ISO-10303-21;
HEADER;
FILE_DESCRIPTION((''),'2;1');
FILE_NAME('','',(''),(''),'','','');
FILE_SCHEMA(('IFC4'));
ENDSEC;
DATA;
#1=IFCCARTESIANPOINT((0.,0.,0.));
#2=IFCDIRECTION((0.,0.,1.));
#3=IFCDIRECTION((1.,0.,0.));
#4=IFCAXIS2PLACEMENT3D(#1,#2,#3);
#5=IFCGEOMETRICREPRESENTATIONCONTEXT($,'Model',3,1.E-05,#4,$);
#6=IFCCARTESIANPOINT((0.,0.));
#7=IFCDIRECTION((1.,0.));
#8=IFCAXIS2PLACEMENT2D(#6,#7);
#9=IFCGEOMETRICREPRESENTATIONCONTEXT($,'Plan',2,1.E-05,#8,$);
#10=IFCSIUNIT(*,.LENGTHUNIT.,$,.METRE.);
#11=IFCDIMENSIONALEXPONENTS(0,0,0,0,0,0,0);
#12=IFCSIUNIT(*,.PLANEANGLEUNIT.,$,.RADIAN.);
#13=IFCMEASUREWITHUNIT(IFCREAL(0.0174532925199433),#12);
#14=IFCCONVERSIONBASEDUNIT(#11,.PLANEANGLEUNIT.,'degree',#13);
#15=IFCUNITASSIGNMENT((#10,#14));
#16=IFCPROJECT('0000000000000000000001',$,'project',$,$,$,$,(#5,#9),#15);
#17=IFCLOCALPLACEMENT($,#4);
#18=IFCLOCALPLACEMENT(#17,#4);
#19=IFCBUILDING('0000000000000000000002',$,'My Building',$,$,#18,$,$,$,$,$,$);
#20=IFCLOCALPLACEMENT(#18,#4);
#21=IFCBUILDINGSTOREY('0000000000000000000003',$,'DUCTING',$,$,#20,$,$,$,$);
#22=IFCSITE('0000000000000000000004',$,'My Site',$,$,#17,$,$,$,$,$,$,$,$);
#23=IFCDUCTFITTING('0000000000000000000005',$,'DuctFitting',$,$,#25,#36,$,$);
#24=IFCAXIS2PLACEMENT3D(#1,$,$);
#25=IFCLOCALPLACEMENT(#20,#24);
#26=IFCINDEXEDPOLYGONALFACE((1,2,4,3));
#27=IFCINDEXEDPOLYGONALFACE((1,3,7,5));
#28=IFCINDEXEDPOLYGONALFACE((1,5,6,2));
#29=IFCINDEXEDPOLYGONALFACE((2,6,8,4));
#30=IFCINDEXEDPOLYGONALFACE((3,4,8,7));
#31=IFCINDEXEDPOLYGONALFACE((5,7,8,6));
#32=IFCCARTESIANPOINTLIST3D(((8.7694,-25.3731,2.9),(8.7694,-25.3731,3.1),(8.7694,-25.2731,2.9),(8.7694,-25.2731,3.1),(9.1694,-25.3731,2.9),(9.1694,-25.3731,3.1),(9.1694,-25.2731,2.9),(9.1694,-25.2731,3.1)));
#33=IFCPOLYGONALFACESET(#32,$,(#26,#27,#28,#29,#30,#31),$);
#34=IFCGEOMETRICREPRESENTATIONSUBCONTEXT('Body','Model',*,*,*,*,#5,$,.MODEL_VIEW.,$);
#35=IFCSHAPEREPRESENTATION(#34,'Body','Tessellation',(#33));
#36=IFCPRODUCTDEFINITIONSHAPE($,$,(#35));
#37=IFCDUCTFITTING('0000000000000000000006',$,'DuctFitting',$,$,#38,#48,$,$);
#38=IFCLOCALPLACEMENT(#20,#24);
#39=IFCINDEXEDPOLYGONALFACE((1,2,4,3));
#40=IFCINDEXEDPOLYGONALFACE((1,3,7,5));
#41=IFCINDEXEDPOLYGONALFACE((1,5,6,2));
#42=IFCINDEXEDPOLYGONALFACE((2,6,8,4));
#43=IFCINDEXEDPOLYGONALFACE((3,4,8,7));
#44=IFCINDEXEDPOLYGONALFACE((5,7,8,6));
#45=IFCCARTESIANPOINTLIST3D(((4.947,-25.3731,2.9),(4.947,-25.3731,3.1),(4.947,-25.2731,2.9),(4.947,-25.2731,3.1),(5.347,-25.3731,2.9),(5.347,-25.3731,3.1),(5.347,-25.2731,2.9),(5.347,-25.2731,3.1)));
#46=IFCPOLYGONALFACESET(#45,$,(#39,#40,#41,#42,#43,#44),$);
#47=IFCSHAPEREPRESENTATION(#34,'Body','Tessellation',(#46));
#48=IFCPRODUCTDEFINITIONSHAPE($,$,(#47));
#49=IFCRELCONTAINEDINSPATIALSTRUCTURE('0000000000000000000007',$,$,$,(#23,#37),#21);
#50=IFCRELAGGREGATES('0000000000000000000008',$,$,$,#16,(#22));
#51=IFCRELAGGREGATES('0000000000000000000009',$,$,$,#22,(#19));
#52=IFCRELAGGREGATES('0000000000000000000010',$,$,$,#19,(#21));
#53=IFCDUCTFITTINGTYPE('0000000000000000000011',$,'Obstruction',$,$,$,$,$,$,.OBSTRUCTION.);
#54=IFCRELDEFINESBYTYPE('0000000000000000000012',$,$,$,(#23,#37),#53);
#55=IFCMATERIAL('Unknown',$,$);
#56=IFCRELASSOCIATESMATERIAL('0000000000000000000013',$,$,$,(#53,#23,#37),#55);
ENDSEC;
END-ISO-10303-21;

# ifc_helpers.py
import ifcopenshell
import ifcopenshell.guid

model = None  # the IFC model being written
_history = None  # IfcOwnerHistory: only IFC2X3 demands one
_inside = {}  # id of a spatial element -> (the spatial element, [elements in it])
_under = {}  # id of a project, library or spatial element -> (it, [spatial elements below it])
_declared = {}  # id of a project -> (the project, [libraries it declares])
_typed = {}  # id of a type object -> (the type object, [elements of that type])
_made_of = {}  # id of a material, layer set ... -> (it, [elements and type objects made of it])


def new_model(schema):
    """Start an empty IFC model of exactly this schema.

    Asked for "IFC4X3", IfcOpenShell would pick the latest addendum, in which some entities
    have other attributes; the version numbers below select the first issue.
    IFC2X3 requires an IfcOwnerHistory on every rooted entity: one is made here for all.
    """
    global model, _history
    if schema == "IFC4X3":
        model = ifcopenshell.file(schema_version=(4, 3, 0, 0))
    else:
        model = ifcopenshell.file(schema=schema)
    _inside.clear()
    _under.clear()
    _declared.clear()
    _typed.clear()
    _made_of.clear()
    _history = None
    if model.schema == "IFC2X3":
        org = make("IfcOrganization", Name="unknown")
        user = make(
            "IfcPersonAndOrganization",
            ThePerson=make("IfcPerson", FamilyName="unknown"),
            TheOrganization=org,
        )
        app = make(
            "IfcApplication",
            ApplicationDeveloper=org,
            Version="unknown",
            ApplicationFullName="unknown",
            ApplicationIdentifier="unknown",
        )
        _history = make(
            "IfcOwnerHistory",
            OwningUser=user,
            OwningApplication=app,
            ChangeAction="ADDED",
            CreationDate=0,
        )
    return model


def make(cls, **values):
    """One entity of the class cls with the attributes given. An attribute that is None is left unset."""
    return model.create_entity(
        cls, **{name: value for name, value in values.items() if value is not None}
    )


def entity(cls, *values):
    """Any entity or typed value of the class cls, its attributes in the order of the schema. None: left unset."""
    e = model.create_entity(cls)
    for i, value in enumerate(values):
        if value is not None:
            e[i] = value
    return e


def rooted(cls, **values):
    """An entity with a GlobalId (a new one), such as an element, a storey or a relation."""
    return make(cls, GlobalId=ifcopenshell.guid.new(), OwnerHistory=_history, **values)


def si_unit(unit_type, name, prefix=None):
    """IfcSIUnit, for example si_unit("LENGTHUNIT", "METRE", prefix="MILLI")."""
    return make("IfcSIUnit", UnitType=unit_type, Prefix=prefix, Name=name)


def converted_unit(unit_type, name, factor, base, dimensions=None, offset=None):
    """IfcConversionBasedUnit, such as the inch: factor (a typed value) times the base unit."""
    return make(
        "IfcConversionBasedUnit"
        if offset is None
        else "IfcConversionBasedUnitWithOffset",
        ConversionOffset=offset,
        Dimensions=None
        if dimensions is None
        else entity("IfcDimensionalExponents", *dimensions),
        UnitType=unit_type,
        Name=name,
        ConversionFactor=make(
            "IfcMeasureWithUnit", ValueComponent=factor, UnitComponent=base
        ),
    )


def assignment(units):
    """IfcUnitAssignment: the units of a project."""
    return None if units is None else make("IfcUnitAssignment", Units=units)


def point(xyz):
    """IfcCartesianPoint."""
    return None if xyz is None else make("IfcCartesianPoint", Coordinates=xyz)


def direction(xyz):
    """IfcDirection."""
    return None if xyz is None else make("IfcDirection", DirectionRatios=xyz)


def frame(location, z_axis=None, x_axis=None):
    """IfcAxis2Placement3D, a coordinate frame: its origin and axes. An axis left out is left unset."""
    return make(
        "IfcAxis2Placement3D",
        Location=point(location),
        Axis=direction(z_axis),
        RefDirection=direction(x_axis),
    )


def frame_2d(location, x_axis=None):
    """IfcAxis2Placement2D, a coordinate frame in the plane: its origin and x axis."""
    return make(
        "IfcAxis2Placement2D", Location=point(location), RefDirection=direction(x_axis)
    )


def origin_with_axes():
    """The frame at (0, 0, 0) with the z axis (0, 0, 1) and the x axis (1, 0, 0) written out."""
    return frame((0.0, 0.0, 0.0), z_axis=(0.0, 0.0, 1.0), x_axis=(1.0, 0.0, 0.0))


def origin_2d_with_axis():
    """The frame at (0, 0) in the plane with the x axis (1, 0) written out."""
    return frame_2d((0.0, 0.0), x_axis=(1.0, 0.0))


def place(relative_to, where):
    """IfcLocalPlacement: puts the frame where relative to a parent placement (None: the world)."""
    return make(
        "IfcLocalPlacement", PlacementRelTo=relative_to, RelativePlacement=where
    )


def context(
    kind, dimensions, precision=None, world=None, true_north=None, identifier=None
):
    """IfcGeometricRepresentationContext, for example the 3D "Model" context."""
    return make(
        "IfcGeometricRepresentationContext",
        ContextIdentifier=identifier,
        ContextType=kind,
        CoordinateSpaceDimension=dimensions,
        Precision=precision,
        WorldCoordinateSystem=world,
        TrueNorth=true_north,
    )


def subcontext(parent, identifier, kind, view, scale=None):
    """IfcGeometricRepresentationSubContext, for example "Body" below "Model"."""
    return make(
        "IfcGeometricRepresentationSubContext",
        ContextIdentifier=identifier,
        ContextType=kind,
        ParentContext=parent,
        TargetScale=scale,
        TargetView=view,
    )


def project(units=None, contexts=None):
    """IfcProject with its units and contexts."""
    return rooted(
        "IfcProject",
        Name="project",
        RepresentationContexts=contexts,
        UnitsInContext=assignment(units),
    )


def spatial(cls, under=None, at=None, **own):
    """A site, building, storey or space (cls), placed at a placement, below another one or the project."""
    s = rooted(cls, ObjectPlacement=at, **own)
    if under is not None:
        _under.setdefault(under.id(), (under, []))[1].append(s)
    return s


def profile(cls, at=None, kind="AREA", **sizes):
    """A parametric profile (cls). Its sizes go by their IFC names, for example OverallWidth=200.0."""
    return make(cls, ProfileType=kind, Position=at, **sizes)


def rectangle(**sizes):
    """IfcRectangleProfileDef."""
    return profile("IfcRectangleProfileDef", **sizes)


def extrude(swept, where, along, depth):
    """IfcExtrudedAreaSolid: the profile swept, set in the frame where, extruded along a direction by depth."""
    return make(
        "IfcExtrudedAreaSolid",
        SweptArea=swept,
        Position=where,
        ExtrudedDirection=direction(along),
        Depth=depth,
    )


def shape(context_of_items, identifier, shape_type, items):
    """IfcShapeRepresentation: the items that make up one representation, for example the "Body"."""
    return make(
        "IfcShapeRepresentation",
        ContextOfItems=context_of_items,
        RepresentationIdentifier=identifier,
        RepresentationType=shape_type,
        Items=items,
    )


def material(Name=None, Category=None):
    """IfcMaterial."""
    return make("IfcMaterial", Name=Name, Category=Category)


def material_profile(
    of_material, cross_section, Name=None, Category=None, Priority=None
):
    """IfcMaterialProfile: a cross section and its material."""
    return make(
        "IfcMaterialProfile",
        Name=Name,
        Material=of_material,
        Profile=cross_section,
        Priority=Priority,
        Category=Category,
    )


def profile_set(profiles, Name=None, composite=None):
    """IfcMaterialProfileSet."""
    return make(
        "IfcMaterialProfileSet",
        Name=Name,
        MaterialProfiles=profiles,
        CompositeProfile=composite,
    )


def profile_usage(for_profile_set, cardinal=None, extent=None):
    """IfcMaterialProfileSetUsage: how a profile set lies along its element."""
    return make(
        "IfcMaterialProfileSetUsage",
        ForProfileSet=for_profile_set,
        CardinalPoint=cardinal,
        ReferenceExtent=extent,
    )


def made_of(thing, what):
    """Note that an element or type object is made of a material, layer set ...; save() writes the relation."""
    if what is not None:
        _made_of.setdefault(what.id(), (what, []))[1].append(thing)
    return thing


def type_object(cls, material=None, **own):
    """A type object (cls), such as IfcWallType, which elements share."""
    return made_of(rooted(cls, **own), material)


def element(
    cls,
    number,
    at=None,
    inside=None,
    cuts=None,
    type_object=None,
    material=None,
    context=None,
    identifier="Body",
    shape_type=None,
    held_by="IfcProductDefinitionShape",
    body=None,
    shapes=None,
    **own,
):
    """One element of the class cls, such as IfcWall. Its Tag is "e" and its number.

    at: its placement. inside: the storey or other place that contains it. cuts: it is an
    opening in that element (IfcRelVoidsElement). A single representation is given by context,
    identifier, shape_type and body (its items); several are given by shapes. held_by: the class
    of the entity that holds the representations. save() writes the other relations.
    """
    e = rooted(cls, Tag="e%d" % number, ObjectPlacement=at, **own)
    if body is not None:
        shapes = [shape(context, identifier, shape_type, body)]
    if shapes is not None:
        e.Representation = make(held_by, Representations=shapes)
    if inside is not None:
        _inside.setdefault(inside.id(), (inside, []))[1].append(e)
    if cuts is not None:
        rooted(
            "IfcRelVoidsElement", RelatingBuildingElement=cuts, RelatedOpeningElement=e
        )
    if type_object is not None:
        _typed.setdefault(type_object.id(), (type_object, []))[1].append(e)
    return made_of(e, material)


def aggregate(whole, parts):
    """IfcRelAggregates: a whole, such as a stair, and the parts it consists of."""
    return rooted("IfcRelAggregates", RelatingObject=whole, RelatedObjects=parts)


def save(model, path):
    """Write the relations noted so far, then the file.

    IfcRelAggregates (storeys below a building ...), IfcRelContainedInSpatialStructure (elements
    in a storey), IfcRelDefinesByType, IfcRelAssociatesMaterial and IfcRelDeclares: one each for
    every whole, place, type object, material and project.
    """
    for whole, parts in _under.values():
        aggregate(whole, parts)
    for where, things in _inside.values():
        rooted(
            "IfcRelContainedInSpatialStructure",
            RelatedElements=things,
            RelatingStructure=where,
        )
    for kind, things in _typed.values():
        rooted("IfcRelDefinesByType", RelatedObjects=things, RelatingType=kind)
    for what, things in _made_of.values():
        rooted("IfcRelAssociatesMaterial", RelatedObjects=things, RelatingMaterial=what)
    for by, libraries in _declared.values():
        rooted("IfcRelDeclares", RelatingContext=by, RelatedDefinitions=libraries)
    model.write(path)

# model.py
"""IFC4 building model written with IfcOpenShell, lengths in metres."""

from ifc_helpers import new_model, entity, si_unit, converted_unit, frame, origin_with_axes, origin_2d_with_axis, place, context, subcontext, project, spatial, rectangle, extrude, material, material_profile, profile_set, profile_usage, type_object, element, save


model = new_model("IFC4")

# Units and contexts
model_context = context("Model", 3, precision=1e-05, world=origin_with_axes())
plan_context = context("Plan", 2, precision=1e-05, world=origin_2d_with_axis())
body_context = subcontext(model_context, "Body", "Model", "MODEL_VIEW")
ifc_project = project(units=[si_unit("LENGTHUNIT", "METRE"), converted_unit("PLANEANGLEUNIT", "degree", entity("IfcReal", 0.0174532925199433), si_unit("PLANEANGLEUNIT", "RADIAN"), dimensions=[0, 0, 0, 0, 0, 0, 0])], contexts=[model_context, plan_context])

# Site, building, storey
site_placement = place(None, origin_with_axes())
site = spatial("IfcSite", under=ifc_project, at=site_placement, Name="My Site")
building_placement = place(site_placement, origin_with_axes())
building = spatial("IfcBuilding", under=site, at=building_placement, Name="My Building")
storey_placement = place(building_placement, origin_with_axes())
storey = spatial("IfcBuildingStorey", under=building, at=storey_placement, Name="DUCTING")

# Shared definitions
ifc_material = material(Name="Unknown")

# Duct fittings
ifc_material_profile_1 = material_profile(ifc_material, rectangle(XDim=0.4, YDim=0.2))
ifc_profile_set_1 = profile_set([ifc_material_profile_1])
duct_fitting_type_1 = type_object("IfcDuctFittingType", Name="Obstruction", PredefinedType="OBSTRUCTION", material=ifc_profile_set_1)
ifc_profile_usage_1 = profile_usage(ifc_profile_set_1, cardinal=5)
duct_fitting_1_placement = place(storey_placement, frame((8.9694, -25.3731, 3.0), z_axis=(0.0, 1.0, 0.0), x_axis=(-1.0, 0.0, 0.0)))
element("IfcDuctFitting", 1, at=duct_fitting_1_placement, inside=storey, type_object=duct_fitting_type_1, material=ifc_profile_usage_1, Name="DuctFitting", context=body_context, shape_type="SweptSolid", body=[
    extrude(rectangle(XDim=0.4, YDim=0.2), origin_with_axes(), (0.0, 0.0, 1.0), 0.1),
])
ifc_profile_usage_2 = profile_usage(ifc_profile_set_1, cardinal=5)
duct_fitting_2_placement = place(storey_placement, frame((5.147, -25.3731, 3.0), z_axis=(0.0, 1.0, 0.0), x_axis=(-1.0, 0.0, 0.0)))
element("IfcDuctFitting", 2, at=duct_fitting_2_placement, inside=storey, type_object=duct_fitting_type_1, material=ifc_profile_usage_2, Name="DuctFitting", context=body_context, shape_type="SweptSolid", body=[
    extrude(rectangle(XDim=0.4, YDim=0.2), origin_with_axes(), (0.0, 0.0, 1.0), 0.1),
])

save(model, "model.ifc")
